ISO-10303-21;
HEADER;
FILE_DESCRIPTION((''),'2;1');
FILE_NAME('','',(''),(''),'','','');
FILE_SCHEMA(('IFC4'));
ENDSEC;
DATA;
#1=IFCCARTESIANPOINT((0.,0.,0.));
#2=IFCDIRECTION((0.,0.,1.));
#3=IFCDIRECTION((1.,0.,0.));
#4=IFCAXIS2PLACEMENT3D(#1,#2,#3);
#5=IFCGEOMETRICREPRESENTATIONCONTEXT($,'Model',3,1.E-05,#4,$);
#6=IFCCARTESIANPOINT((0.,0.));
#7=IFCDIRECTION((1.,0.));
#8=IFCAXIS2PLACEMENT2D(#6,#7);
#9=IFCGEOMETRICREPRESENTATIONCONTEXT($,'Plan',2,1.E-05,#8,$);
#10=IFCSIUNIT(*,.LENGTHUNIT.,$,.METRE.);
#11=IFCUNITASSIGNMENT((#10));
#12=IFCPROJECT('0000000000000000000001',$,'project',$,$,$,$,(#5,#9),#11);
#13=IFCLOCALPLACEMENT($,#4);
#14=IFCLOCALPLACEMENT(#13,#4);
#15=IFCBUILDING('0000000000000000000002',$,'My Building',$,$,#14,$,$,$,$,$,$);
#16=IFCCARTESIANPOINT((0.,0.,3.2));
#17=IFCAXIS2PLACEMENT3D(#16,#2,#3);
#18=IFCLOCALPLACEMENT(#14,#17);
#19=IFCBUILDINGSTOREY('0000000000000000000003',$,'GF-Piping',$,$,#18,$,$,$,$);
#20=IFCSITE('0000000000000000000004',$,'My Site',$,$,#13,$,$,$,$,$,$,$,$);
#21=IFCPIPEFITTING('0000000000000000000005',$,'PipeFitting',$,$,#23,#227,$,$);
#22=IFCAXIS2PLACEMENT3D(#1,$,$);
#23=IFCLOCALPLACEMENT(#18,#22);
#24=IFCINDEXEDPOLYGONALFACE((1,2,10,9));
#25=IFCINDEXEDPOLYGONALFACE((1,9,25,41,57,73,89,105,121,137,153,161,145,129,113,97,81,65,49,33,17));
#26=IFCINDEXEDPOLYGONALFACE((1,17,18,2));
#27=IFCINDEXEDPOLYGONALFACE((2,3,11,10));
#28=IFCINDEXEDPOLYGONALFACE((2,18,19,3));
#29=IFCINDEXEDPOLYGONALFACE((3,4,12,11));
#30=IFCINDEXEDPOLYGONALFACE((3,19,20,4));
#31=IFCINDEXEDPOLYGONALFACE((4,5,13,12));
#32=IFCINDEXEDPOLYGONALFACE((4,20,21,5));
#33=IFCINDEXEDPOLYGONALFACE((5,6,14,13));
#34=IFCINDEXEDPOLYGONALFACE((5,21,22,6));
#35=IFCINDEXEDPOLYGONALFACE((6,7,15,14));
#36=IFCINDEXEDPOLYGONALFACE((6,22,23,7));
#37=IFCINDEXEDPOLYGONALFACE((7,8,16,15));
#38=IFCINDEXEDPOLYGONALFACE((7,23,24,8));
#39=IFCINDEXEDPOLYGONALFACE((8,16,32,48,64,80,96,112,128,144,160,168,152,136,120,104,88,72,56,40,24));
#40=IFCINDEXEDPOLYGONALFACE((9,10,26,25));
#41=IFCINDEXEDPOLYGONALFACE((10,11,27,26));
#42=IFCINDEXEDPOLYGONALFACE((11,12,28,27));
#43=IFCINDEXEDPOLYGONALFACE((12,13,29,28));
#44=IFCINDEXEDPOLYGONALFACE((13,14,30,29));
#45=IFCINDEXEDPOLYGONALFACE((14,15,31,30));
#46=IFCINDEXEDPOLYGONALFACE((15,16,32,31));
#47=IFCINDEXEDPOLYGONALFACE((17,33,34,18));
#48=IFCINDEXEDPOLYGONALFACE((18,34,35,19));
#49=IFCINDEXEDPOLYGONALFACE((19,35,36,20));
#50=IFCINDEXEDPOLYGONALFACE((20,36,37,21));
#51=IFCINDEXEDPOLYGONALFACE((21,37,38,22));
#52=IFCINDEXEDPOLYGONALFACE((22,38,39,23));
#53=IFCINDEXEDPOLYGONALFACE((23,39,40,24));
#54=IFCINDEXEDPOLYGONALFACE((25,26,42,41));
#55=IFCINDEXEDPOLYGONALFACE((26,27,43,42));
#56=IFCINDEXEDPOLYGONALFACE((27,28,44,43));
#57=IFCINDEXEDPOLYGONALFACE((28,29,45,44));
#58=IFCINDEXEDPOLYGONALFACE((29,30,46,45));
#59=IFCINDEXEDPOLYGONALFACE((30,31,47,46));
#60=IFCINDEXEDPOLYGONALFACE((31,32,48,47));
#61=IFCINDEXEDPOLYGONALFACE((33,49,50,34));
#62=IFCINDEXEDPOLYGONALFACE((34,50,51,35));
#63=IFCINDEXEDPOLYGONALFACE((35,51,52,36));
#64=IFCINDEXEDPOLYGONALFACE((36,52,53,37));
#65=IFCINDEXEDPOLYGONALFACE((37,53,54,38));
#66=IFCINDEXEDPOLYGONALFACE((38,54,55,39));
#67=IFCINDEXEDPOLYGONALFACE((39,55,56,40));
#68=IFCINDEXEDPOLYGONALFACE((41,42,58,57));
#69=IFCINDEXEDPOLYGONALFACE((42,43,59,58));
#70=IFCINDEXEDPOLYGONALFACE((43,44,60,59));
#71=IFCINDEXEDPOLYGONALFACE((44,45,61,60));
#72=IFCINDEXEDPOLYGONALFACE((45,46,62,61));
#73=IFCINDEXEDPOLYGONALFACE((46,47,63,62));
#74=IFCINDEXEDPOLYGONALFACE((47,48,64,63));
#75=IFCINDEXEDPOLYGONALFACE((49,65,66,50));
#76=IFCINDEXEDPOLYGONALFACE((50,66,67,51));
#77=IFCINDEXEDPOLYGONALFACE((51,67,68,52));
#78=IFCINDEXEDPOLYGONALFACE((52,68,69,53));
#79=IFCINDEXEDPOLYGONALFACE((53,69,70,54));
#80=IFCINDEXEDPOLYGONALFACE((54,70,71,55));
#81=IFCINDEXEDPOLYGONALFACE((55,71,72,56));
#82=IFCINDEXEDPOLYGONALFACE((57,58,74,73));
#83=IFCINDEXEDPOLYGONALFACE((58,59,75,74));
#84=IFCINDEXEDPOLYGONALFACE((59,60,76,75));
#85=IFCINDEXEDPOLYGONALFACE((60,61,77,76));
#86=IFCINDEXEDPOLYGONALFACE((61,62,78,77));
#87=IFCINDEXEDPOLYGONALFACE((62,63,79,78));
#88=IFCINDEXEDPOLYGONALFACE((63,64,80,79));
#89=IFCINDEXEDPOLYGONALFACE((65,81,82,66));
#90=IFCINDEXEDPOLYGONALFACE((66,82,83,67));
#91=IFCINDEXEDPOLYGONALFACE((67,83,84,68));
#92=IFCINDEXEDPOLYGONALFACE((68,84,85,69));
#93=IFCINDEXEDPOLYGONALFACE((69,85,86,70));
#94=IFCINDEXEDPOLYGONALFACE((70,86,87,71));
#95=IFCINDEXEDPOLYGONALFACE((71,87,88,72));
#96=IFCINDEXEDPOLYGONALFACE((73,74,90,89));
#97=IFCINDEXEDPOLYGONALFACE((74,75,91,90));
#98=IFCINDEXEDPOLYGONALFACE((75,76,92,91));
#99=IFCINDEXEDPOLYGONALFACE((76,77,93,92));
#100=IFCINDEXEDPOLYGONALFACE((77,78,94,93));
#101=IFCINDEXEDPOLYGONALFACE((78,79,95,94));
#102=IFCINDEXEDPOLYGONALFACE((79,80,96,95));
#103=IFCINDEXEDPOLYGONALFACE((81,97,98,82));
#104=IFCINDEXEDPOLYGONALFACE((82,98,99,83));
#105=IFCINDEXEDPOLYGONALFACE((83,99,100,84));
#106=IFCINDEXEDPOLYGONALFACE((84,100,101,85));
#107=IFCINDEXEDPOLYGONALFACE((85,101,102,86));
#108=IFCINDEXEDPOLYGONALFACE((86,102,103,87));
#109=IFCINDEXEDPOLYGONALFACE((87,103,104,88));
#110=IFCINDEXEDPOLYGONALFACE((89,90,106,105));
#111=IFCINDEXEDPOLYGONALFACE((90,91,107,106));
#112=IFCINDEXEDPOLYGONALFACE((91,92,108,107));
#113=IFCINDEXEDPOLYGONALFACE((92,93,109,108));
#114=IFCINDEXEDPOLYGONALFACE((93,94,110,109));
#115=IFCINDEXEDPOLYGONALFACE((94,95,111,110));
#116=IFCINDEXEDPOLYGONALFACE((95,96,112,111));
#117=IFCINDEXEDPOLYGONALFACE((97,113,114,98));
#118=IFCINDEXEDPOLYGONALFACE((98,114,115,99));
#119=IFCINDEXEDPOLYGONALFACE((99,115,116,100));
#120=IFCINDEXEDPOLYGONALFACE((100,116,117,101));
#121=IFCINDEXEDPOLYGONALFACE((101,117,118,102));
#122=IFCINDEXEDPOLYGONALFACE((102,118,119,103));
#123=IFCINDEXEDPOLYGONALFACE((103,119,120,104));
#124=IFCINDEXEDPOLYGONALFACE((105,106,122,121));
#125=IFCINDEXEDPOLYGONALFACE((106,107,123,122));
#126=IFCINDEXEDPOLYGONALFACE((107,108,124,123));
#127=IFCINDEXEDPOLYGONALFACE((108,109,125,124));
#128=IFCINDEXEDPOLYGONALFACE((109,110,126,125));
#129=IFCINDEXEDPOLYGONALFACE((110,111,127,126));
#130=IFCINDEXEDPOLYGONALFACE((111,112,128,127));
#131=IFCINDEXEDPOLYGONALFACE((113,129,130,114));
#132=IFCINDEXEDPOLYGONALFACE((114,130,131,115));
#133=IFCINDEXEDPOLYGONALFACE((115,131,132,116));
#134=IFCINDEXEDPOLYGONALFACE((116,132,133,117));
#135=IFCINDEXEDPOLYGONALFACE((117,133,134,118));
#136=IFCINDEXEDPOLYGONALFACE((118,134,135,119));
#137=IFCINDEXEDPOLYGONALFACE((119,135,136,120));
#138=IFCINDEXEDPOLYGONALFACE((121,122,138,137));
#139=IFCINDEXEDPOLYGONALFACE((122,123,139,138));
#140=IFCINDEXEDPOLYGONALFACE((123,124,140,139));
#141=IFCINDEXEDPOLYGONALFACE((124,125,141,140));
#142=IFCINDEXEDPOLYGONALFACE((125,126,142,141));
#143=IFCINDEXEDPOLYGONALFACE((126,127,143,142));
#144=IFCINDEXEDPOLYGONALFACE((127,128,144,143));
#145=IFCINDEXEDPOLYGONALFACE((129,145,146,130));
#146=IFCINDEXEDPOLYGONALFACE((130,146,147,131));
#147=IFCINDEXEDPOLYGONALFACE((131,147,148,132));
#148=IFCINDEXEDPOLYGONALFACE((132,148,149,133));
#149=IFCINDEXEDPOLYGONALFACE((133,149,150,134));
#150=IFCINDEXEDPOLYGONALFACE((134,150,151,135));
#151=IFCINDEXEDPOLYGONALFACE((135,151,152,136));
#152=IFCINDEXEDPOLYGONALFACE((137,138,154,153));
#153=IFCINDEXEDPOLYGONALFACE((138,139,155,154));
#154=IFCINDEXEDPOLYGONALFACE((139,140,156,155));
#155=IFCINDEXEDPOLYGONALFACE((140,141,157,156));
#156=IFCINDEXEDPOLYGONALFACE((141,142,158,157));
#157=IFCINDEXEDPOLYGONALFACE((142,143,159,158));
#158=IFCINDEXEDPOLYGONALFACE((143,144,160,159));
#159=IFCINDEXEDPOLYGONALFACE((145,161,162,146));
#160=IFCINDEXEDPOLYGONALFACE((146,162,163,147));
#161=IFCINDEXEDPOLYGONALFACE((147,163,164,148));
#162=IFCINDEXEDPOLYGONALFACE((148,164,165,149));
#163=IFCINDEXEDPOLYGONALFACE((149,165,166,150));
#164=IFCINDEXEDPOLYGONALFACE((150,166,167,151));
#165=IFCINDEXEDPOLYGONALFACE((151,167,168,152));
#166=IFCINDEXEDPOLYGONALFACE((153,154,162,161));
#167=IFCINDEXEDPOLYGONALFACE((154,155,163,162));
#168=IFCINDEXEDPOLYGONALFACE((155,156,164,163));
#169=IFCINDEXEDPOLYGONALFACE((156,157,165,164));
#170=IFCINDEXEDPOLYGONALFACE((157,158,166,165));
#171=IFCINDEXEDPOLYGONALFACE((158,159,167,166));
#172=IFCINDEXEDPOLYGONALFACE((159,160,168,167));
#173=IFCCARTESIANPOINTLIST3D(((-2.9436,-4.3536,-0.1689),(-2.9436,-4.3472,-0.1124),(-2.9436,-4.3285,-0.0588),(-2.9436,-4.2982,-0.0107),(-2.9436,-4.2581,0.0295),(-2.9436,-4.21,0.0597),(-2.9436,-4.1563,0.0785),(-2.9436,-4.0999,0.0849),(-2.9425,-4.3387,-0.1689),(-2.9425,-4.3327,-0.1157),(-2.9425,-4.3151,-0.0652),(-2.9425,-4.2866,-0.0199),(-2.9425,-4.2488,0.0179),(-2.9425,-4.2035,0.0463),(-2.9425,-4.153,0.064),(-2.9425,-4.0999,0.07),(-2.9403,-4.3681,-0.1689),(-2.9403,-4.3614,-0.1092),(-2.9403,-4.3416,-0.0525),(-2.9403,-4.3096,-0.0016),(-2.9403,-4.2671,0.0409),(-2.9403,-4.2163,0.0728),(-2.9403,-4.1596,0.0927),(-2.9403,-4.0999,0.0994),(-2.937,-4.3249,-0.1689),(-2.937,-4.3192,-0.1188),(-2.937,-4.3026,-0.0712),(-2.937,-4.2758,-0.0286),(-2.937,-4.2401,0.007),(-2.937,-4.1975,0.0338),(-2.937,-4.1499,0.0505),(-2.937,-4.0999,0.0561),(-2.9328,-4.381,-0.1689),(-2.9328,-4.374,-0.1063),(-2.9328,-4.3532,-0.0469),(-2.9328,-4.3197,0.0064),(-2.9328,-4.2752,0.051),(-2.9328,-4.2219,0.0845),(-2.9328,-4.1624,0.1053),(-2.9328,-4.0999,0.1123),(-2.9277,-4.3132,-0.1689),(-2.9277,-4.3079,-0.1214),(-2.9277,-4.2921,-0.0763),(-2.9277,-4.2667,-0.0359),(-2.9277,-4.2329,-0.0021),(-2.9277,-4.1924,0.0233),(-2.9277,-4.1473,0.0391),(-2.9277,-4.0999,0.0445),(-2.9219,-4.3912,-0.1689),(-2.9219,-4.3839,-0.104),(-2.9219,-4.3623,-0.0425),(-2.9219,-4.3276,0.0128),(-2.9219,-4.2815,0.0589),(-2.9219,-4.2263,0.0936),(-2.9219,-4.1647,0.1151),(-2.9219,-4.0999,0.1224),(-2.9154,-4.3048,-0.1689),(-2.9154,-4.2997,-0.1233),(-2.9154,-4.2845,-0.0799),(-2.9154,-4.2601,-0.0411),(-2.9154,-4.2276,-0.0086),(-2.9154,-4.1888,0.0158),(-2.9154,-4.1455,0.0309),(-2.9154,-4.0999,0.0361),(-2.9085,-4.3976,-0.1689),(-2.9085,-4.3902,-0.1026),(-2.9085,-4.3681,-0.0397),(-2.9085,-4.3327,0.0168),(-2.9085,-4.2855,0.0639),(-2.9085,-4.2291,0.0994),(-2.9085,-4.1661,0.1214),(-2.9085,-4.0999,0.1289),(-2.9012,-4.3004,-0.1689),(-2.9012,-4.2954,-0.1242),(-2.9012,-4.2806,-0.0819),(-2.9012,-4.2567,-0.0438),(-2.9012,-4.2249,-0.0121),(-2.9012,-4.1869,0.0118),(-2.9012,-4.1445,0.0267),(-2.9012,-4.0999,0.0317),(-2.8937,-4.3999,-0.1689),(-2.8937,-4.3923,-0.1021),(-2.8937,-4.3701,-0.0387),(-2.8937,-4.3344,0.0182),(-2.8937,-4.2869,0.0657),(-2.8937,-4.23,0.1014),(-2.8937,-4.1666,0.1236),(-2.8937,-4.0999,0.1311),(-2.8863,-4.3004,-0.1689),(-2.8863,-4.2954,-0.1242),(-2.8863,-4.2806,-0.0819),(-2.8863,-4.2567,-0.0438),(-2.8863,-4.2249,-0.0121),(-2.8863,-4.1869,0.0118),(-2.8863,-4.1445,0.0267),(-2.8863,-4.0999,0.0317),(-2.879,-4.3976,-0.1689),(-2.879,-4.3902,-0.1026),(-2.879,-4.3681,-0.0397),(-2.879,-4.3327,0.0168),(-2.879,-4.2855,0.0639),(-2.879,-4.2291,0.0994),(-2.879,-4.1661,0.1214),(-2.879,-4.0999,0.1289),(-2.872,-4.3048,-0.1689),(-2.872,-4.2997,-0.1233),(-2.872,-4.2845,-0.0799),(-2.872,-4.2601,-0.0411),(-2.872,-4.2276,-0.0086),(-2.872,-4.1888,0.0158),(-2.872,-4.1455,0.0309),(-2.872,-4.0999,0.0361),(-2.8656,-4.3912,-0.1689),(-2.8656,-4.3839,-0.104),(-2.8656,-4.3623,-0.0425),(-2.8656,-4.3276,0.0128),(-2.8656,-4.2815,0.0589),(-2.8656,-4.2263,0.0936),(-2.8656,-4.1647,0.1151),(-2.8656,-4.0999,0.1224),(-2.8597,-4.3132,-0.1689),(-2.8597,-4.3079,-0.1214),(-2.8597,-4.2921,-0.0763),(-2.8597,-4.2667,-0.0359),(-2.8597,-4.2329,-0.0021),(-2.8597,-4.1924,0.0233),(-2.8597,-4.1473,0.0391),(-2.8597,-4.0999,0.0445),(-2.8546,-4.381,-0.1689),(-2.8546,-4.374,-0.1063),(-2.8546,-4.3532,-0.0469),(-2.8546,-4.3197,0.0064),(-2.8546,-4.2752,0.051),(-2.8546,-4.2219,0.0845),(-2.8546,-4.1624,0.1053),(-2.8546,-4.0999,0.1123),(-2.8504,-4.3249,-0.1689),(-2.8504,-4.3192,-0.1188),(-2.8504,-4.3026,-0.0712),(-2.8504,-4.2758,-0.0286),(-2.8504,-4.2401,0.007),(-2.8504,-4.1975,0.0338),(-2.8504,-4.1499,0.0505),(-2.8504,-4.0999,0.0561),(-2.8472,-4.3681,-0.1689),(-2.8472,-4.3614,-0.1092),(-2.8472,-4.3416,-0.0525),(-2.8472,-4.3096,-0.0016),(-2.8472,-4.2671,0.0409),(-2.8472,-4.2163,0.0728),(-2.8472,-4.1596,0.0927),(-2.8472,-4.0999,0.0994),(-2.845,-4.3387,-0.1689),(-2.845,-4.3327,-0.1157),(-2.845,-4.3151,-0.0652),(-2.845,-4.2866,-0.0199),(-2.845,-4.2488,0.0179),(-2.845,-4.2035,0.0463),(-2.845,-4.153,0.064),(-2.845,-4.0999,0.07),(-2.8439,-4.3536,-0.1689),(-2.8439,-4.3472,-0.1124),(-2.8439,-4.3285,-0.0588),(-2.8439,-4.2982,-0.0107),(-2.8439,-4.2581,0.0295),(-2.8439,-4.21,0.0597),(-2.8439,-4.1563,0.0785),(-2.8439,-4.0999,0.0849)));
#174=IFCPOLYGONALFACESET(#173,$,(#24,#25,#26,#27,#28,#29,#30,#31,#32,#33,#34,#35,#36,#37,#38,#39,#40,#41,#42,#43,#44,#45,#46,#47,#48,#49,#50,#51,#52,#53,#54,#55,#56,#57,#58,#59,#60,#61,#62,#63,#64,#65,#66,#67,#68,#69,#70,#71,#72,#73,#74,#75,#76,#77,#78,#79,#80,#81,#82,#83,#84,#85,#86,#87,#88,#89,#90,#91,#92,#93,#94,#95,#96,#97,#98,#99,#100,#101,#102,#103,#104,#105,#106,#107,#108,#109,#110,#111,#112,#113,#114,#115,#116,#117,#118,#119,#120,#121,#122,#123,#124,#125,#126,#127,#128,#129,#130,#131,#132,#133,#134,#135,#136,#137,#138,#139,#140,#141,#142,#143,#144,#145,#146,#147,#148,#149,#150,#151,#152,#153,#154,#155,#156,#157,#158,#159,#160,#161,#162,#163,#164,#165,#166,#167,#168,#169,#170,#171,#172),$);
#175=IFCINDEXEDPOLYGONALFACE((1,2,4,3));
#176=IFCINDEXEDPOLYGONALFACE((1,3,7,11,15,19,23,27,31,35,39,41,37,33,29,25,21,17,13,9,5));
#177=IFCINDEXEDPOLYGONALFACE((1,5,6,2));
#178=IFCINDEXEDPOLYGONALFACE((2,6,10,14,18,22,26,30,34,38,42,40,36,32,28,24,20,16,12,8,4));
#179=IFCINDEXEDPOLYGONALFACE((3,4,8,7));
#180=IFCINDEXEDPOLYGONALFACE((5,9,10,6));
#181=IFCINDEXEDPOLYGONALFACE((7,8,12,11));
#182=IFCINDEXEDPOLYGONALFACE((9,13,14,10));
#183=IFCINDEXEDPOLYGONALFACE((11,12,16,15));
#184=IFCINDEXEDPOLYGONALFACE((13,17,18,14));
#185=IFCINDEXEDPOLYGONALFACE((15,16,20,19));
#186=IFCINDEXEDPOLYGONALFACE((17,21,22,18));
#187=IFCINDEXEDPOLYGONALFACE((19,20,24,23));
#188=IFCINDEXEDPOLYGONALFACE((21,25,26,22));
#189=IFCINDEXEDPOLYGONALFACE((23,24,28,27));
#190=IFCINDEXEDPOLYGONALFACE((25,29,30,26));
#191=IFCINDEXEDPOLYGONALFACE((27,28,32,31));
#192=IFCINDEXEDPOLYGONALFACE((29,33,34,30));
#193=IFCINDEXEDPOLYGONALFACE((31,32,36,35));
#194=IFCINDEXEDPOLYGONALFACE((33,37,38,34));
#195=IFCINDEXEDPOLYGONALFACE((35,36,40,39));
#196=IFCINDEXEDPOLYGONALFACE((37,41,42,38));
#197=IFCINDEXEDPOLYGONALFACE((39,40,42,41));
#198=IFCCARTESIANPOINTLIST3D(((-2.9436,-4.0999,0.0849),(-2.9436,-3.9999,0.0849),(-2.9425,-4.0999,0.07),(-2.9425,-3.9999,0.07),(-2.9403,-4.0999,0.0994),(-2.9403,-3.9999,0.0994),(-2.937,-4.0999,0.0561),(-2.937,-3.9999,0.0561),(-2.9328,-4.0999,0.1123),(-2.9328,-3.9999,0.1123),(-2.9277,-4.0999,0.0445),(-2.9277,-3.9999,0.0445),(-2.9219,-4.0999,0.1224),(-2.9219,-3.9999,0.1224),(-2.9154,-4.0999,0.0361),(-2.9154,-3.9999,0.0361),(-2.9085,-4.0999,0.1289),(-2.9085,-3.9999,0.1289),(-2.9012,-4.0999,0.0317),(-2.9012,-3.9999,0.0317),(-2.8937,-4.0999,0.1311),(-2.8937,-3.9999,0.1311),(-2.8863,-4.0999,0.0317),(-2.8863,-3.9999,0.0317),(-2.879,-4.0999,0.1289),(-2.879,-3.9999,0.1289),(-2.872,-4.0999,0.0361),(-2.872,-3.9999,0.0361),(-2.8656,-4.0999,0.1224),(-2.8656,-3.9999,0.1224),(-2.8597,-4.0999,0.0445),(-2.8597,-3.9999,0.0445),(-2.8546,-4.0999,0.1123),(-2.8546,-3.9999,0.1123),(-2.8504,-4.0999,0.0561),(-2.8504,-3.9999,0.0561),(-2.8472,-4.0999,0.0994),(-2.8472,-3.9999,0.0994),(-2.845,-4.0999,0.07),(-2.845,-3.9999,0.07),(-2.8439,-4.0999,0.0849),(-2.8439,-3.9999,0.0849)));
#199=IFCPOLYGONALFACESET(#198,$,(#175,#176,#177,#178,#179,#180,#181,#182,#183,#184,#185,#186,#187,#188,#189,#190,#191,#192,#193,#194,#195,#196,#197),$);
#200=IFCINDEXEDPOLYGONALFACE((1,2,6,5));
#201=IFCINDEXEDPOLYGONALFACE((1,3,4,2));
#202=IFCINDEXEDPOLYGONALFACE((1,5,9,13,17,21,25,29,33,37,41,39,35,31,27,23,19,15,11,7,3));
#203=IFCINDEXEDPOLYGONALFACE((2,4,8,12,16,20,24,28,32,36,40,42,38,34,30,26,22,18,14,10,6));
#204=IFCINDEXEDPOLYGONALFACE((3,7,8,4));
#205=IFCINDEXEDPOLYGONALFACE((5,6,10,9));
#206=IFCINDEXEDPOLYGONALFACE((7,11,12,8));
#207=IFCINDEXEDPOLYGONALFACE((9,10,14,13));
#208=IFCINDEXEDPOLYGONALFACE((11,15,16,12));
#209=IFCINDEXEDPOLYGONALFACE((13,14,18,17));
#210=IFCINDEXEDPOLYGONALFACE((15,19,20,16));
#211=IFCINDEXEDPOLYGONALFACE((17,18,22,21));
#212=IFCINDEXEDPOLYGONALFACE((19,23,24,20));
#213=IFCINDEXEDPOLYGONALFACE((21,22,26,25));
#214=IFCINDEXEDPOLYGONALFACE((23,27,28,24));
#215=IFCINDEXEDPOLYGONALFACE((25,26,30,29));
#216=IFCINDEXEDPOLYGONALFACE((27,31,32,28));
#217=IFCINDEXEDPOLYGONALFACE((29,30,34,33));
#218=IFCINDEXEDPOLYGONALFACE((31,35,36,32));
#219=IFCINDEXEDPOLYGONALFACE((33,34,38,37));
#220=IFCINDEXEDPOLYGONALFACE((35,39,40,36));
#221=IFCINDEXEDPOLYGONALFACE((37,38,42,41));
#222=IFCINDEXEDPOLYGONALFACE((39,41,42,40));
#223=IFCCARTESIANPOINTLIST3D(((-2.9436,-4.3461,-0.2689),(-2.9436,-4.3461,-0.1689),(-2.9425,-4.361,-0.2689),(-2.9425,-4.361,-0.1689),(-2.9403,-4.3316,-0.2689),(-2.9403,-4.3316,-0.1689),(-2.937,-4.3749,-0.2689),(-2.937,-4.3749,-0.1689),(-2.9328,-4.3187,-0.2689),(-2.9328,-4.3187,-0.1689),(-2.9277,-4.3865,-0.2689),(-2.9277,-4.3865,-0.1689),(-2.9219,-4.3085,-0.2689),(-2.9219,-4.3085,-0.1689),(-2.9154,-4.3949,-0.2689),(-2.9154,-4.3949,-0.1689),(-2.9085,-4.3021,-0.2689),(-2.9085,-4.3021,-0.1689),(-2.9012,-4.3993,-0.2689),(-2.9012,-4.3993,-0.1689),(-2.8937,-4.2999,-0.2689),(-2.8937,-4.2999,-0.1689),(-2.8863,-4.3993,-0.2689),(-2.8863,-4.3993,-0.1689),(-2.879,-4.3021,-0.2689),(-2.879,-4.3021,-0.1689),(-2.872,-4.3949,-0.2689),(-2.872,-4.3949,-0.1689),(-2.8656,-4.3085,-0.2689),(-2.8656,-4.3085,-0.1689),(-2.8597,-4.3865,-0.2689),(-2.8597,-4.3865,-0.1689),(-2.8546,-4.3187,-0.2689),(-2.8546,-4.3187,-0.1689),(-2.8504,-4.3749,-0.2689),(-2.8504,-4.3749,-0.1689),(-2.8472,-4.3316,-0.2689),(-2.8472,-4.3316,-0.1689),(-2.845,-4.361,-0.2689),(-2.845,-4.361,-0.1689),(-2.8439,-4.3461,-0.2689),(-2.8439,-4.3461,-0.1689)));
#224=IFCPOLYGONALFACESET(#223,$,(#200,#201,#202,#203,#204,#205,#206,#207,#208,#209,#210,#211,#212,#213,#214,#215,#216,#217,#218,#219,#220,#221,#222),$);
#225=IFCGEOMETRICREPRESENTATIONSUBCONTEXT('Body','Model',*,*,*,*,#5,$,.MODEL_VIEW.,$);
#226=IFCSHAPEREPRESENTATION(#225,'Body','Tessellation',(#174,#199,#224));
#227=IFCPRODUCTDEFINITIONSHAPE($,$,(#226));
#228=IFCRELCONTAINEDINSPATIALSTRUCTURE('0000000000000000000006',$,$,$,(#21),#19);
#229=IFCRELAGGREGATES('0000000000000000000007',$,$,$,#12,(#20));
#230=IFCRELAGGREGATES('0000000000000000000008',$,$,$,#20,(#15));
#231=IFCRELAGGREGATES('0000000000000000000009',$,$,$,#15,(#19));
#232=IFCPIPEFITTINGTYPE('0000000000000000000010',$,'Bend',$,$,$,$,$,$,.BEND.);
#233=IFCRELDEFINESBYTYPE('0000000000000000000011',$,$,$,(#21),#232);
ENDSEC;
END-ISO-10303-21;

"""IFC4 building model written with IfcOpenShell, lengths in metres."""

from ifc_helpers import new_model, entity, si_unit, frame, origin_with_axes, origin_2d_with_axis, place, context, subcontext, project, spatial, circle, extrude, source, transform, mapped, type_object, type_shapes, element, save


model = new_model("IFC4")

# Units and contexts
model_context = context("Model", 3, precision=1e-05, world=origin_with_axes())
plan_context = context("Plan", 2, precision=1e-05, world=origin_2d_with_axis())
body_context = subcontext(model_context, "Body", "Model", "MODEL_VIEW")
ifc_project = project(units=[si_unit("LENGTHUNIT", "METRE")], contexts=[model_context, plan_context])

# Site, building, storey
site_placement = place(None, origin_with_axes())
site = spatial("IfcSite", under=ifc_project, at=site_placement, Name="My Site")
building_placement = place(site_placement, origin_with_axes())
building = spatial("IfcBuilding", under=site, at=building_placement, Name="My Building")
storey_placement = place(building_placement, frame((0.0, 0.0, 3.2), z_axis=(0.0, 0.0, 1.0), x_axis=(1.0, 0.0, 0.0)))
storey = spatial("IfcBuildingStorey", under=building, at=storey_placement, Name="GF-Piping")

# Pipe fitting
pipe_fitting_type = type_object("IfcPipeFittingType", Name="Bend", PredefinedType="BEND")
shared_shape = source(origin_with_axes(), body_context, "Body", "SolidModel", [
    entity("IfcSweptDiskSolid", entity("IfcIndexedPolyCurve", entity("IfcCartesianPointList3D", [[0.0, 0.0, 0.1], [-0.0732, 0.0, 0.2768], [-0.25, 0.0, 0.35]]), [entity("IfcArcIndex", [1, 2, 3])]), 0.05),
    extrude(circle(Radius=0.05), origin_with_axes(), (0.0, 0.0, 1.0), 0.1),
    extrude(circle(Radius=0.05), frame((-0.25, 0.0, 0.35), z_axis=(-1.0, 0.0, 0.0), x_axis=(0.0, 0.0, -1.0)), (0.0, 0.0, 1.0), 0.1),
])
type_shapes(pipe_fitting_type, [shared_shape])
for number, where, z_axis, x_axis, name in (
    (1, (-2.8937, -3.9999, 0.0811), (0.0, -1.0, 0.0), (0.0, 0.0, 1.0), "PipeFitting"),
):
    element("IfcPipeFitting", number, at=place(storey_placement, frame(where, z_axis=z_axis, x_axis=x_axis)), inside=storey, type_object=pipe_fitting_type, Name=name, context=body_context, shape_type="MappedRepresentation", body=[
        mapped(shared_shape, transform((0.0, 0.0, 0.0), x_axis=(1.0, 0.0, 0.0), y_axis=(0.0, 1.0, 0.0), z_axis=(0.0, 0.0, 1.0), scale=1.0)),
    ])

save(model, "model.ifc")
